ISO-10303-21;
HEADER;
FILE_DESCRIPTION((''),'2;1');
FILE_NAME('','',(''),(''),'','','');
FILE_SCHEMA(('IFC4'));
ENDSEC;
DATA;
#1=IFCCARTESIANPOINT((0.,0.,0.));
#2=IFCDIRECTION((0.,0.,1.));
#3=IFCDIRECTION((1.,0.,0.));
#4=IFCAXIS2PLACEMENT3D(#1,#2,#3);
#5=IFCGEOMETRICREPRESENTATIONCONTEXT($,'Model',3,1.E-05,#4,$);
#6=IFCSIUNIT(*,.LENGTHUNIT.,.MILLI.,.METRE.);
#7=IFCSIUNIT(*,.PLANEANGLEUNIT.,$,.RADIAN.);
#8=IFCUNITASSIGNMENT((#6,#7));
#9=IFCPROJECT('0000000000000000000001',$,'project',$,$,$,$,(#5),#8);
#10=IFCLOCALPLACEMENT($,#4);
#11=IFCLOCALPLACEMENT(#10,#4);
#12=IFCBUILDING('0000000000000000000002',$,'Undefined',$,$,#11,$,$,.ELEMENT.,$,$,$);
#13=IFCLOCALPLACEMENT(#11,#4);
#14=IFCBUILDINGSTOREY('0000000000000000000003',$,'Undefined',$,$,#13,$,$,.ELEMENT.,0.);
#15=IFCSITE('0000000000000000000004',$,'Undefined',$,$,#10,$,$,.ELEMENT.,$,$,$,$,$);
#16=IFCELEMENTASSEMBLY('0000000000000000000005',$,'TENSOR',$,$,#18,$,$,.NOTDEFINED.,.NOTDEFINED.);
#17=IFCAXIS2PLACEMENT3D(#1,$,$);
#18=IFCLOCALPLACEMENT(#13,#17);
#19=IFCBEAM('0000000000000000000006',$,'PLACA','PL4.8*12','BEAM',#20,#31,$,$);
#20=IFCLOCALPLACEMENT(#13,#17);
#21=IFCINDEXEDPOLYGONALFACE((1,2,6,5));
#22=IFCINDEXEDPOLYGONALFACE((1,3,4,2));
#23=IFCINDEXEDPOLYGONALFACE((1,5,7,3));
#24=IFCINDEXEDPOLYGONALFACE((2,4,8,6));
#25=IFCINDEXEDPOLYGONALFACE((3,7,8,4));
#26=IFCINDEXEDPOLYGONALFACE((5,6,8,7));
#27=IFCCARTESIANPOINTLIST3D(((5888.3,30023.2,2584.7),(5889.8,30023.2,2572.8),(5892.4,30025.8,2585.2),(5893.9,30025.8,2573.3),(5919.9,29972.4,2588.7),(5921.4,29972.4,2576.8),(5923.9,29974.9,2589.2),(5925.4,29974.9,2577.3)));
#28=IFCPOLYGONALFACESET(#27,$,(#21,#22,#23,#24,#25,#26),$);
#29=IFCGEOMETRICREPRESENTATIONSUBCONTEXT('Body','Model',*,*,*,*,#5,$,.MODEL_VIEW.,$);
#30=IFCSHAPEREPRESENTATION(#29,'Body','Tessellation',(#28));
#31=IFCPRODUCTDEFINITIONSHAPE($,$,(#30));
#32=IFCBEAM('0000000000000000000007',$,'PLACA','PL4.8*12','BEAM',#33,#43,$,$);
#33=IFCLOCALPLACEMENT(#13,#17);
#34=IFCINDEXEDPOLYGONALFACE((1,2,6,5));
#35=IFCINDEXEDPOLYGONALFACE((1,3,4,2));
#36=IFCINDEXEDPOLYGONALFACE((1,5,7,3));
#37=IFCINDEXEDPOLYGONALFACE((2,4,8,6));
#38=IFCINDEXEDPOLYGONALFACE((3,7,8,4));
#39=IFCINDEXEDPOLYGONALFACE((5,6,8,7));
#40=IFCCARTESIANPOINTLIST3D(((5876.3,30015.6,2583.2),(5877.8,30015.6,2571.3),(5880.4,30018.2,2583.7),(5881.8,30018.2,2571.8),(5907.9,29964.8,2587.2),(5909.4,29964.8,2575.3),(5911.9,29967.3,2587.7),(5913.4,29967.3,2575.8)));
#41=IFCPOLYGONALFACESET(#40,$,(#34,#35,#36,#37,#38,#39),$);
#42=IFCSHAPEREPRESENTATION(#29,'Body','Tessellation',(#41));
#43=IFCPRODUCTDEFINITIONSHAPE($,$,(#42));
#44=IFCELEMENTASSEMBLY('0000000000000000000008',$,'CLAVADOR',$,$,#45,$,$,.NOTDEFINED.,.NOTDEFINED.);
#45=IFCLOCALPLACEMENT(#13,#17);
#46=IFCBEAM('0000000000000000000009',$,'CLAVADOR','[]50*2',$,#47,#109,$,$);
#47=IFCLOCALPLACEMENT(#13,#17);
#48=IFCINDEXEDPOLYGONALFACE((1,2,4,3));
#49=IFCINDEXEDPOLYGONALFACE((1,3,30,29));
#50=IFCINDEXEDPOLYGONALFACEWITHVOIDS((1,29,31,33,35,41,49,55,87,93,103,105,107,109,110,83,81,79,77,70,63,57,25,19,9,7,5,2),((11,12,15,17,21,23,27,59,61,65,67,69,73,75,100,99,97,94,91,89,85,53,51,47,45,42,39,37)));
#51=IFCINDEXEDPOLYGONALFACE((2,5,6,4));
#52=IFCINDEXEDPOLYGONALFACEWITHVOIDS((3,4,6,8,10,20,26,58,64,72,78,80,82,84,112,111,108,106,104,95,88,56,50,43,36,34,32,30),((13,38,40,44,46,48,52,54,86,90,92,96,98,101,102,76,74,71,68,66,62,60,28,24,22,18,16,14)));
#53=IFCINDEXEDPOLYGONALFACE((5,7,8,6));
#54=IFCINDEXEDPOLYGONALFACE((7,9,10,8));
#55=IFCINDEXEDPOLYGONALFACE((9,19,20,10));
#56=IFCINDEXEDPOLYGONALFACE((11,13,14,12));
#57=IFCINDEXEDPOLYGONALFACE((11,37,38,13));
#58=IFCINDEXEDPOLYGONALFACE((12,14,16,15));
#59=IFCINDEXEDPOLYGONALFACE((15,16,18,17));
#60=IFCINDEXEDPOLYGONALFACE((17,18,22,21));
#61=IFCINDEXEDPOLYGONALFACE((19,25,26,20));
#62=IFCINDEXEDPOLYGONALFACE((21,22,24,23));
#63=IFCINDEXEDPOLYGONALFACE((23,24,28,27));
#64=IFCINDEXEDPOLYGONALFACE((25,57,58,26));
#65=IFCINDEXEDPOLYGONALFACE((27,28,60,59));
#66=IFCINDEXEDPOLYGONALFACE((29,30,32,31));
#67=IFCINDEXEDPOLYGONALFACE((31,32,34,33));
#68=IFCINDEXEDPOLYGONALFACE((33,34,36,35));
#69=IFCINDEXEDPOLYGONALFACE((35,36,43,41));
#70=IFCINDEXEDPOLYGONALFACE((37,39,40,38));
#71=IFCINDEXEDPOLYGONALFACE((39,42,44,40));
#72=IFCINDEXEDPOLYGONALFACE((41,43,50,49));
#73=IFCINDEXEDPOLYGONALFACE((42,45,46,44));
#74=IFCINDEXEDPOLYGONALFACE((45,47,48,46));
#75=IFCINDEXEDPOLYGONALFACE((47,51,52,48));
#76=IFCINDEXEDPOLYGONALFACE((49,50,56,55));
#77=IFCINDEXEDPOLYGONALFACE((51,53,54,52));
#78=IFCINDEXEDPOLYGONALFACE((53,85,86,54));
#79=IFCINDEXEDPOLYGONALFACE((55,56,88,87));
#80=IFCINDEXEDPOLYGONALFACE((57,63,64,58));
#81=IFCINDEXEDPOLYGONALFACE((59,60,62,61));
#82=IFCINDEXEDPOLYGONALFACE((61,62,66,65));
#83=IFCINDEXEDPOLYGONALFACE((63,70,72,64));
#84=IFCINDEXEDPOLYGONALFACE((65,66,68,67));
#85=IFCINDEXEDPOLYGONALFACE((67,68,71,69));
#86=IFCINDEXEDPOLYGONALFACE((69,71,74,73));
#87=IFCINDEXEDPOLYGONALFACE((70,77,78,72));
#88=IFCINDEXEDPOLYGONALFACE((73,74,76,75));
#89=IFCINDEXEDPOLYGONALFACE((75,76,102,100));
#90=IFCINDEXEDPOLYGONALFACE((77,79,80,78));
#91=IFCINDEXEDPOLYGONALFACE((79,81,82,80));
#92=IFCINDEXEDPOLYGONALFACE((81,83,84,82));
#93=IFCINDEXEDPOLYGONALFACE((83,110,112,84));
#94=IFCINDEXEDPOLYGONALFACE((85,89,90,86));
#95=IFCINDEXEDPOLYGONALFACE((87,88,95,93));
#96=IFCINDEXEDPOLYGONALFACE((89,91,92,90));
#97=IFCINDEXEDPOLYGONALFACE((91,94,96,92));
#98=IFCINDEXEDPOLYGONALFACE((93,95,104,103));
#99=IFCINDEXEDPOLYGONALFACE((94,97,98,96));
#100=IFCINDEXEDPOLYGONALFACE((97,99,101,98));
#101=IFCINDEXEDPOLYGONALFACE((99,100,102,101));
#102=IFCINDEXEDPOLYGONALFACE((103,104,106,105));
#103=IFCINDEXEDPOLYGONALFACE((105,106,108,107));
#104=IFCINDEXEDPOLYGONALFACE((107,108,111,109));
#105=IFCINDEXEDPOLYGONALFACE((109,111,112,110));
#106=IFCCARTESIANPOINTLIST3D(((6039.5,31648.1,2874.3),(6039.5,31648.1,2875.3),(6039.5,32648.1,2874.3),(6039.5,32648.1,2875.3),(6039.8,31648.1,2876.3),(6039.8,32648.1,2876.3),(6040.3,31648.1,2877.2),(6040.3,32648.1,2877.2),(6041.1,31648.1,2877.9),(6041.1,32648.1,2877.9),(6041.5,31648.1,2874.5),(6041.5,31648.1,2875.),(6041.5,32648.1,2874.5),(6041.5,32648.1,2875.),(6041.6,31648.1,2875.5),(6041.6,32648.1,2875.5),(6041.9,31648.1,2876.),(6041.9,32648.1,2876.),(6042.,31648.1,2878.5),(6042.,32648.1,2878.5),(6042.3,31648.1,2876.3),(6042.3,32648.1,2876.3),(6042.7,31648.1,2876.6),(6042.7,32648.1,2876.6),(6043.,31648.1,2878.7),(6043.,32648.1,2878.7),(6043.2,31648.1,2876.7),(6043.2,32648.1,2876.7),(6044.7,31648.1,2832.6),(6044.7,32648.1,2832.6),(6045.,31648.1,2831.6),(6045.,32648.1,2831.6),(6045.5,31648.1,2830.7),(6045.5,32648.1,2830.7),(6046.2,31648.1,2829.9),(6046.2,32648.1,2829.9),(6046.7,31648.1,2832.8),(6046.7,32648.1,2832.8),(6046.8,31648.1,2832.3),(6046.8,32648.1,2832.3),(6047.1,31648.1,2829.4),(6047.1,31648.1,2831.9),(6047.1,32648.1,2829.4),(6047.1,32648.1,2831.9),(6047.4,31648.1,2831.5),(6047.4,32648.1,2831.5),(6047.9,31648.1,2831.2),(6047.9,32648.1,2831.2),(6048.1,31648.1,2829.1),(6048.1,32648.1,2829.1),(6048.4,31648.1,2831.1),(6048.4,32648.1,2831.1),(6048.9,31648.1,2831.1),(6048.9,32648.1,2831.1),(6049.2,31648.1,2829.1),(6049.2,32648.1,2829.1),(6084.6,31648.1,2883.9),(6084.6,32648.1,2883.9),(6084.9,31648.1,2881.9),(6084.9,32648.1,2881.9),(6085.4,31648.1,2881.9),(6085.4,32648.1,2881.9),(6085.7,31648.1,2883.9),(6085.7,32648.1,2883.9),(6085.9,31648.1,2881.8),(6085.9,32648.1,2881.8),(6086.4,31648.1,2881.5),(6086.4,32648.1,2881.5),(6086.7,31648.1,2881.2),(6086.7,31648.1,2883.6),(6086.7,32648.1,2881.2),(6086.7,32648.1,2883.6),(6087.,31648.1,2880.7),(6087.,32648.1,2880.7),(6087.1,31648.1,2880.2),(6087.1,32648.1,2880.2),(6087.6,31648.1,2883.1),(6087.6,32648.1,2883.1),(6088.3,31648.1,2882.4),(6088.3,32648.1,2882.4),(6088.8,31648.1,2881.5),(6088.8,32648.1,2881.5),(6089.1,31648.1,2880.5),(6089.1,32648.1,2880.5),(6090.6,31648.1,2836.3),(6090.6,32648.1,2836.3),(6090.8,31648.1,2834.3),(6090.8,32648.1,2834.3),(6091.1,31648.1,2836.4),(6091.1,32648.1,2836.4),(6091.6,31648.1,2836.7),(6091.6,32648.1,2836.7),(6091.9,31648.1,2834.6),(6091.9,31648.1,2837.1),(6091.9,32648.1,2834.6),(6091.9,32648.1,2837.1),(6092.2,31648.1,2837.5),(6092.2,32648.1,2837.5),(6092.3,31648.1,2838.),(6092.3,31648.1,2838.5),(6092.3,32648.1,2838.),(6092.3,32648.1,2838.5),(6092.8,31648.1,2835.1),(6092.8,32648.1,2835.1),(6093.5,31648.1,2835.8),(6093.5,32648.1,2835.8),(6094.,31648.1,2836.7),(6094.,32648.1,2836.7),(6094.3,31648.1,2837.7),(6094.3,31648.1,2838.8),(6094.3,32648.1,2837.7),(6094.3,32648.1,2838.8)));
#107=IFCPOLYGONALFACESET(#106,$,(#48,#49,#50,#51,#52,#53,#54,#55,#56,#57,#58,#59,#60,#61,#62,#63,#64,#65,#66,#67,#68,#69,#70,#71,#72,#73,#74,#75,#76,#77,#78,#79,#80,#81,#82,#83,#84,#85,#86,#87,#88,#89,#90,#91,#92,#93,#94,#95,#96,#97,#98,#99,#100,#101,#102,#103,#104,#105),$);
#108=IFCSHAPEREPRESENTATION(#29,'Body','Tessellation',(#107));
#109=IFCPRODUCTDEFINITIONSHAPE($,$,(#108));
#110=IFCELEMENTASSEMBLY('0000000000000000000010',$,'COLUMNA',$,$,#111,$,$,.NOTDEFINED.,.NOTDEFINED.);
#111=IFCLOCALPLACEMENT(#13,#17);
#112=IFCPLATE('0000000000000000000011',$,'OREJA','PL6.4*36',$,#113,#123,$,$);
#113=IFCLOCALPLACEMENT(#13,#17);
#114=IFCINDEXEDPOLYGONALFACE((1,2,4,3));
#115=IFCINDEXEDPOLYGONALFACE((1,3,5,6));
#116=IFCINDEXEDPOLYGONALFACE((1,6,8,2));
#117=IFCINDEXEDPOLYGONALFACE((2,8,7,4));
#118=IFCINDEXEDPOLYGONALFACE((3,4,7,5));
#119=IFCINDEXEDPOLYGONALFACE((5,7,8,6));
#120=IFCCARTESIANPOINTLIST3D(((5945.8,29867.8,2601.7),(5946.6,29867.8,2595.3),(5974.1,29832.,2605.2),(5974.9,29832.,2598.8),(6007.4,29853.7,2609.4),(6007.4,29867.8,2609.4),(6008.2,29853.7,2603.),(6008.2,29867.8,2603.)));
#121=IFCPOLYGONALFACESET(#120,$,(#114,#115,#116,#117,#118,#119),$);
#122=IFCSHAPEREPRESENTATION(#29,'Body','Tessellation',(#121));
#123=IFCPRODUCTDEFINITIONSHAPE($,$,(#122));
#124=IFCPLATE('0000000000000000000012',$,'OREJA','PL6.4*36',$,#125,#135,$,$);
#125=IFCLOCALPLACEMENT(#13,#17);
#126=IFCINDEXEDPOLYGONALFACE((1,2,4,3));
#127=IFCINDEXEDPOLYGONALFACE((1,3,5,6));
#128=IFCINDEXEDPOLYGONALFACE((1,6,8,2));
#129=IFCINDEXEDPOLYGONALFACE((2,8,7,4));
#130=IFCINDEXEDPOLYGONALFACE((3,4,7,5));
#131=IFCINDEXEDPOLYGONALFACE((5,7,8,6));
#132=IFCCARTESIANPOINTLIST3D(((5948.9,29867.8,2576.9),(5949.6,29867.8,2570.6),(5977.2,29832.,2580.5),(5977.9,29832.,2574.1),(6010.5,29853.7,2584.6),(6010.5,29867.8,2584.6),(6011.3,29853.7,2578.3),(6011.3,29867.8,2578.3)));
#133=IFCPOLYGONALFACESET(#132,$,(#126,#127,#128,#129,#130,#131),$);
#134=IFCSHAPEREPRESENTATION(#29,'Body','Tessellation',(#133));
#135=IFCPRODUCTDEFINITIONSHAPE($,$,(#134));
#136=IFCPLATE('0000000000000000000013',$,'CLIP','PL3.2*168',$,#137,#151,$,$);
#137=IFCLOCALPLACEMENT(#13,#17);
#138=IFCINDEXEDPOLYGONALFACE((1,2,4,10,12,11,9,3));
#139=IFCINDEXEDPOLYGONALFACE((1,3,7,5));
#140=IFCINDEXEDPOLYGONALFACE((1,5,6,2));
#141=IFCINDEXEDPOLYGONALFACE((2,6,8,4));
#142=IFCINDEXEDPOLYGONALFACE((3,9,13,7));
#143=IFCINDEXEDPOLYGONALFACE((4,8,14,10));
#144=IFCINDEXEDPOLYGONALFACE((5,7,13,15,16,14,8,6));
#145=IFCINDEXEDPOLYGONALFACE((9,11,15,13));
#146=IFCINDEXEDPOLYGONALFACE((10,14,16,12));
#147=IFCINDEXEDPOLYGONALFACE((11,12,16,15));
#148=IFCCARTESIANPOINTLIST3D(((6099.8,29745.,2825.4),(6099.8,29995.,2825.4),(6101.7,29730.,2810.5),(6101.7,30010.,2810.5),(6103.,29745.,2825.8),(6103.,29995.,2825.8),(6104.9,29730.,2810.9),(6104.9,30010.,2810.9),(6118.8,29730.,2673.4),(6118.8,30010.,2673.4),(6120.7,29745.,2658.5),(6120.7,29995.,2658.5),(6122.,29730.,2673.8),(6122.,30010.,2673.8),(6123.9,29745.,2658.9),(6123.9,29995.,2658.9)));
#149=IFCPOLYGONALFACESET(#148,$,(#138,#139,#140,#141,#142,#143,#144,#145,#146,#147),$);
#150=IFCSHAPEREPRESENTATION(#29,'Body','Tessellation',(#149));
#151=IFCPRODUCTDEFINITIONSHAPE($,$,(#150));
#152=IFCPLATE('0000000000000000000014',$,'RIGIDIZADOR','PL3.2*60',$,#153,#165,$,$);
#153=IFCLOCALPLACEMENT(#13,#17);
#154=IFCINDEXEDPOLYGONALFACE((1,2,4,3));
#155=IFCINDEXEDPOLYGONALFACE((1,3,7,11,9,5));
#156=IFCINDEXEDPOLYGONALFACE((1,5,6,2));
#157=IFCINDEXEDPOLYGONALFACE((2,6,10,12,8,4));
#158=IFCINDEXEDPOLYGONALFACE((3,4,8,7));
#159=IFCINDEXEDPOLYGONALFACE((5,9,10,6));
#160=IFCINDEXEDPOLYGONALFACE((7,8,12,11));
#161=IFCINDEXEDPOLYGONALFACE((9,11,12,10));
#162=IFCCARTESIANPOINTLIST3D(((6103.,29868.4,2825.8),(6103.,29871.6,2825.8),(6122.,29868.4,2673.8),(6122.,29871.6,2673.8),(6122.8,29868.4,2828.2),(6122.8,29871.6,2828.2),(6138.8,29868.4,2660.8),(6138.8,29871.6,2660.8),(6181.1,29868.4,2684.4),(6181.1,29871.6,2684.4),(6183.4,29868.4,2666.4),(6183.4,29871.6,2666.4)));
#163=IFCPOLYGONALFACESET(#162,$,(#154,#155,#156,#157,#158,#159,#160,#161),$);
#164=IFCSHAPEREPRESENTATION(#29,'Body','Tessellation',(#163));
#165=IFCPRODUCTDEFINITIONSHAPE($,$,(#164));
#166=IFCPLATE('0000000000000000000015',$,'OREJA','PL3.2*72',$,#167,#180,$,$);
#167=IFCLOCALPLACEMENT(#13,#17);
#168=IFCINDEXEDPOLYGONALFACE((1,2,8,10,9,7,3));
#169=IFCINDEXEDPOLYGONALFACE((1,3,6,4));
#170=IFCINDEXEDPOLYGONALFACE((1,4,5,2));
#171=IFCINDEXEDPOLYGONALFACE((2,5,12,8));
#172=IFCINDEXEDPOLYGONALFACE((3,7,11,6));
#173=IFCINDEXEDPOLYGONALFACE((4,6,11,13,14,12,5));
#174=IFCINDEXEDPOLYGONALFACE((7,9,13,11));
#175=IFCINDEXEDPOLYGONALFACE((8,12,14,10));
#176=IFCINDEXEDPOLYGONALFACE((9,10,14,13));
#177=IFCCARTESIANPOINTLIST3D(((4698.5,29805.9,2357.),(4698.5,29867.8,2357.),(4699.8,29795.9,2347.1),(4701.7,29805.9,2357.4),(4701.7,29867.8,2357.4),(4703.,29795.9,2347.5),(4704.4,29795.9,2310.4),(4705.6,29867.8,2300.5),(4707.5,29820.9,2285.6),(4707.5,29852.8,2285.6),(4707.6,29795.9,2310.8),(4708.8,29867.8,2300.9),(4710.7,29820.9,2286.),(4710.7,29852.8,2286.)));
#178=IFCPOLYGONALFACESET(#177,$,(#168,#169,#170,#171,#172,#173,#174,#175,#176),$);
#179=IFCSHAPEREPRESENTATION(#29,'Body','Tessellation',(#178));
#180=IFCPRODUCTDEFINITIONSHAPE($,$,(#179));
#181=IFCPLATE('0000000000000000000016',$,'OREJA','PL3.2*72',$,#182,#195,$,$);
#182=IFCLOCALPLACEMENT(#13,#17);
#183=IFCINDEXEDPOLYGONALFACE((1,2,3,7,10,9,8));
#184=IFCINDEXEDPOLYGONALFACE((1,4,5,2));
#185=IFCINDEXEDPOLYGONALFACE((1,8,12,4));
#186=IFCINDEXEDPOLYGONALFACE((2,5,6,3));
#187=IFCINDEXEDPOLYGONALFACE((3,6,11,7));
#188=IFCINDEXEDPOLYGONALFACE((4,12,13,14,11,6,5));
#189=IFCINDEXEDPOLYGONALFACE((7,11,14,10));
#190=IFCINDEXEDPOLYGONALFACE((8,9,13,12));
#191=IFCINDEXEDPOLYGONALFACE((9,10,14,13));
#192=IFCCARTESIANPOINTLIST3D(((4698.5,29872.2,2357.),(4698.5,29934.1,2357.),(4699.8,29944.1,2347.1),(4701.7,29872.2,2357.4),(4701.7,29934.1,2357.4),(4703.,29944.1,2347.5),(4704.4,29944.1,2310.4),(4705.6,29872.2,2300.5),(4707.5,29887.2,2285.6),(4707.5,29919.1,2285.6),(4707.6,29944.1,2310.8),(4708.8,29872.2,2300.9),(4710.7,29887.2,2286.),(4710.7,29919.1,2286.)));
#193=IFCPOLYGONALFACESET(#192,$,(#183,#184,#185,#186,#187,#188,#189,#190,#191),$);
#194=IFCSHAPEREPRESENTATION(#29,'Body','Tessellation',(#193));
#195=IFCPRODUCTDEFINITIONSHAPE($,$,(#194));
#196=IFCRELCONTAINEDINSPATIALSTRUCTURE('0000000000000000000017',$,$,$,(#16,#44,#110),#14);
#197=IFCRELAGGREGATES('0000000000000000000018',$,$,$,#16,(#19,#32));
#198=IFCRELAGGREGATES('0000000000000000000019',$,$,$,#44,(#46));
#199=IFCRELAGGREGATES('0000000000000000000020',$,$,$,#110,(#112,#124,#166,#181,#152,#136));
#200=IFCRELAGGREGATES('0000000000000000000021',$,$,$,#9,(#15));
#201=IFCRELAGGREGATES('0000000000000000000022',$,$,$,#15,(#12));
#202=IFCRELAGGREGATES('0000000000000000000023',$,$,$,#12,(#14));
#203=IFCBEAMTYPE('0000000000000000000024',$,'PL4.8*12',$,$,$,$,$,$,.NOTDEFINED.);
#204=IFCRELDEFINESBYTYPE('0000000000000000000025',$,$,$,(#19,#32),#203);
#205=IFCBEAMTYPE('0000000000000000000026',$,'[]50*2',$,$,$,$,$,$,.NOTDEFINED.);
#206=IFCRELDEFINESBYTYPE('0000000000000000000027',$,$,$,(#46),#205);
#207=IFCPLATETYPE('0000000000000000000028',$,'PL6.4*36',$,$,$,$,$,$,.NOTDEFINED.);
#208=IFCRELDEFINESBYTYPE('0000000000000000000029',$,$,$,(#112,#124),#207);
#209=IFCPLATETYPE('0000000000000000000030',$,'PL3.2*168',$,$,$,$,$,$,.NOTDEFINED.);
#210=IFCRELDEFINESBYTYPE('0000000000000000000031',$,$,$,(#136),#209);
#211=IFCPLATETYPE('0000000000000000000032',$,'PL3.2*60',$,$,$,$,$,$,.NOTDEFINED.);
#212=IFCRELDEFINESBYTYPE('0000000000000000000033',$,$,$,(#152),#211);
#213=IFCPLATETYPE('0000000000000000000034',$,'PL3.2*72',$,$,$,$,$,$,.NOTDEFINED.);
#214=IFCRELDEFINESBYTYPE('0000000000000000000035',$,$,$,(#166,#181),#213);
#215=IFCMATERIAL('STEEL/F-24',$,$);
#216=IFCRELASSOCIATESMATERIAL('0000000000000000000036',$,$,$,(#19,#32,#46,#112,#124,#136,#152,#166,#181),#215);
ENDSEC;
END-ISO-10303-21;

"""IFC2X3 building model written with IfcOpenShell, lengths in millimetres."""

from ifc_helpers import new_model, si_unit, frame, origin_with_axes, origin_2d_with_axis, place, context, subcontext, project, spatial, polyline, rectangle, hollow_rectangle, outline, extrude, material, type_object, element, aggregate, save


model = new_model("IFC2X3")

# Units and contexts
model_context = context("Model", 3, precision=1e-05, world=origin_with_axes())
body_context = subcontext(model_context, "Body", "Model", "MODEL_VIEW")
ifc_project = project(units=[si_unit("LENGTHUNIT", "METRE", prefix="MILLI"), si_unit("PLANEANGLEUNIT", "RADIAN")], contexts=[model_context])

# Site, building, storey
site_placement = place(None, origin_with_axes())
site = spatial("IfcSite", under=ifc_project, at=site_placement, Name="Undefined", CompositionType="ELEMENT")
building_placement = place(site_placement, origin_with_axes())
building = spatial("IfcBuilding", under=site, at=building_placement, Name="Undefined", CompositionType="ELEMENT")
storey_placement = place(building_placement, origin_with_axes())
storey = spatial("IfcBuildingStorey", under=building, at=storey_placement, Name="Undefined", CompositionType="ELEMENT", Elevation=0.0)

# Element assembly, beams
assembly_1_placement = place(storey_placement, origin_with_axes())
assembly_1 = element("IfcElementAssembly", 1, at=assembly_1_placement, inside=storey, Name="TENSOR", AssemblyPlace="NOTDEFINED", PredefinedType="NOTDEFINED")
ifc_material_1 = material(Name="STEEL/F-24")
beam_type_1 = type_object("IfcBeamType", Name="PL4.8*12", PredefinedType="NOTDEFINED")
beam_1_placement = place(assembly_1_placement, frame((5891.1, 30024.5, 2579.0), z_axis=(0.124075, 0.0, -0.992273), x_axis=(0.526076, -0.84789, 0.065781)))
beam_1 = element("IfcBeam", 2, at=beam_1_placement, type_object=beam_type_1, material=ifc_material_1, Name="PLACA", Description="PL4.8*12", ObjectType="BEAM", context=body_context, shape_type="SweptSolid", body=[
    extrude(rectangle(XDim=4.8, YDim=12.0, at=origin_2d_with_axis()), frame((60.0, 0.0, 0.0), z_axis=(-1.0, 0.0, 0.0), x_axis=(0.0, -1.0, 0.0)), (0.0, 0.0, 1.0), 60.0),
])
beam_2_placement = place(assembly_1_placement, frame((5879.1, 30016.9, 2577.5), z_axis=(0.124075, 0.0, -0.992273), x_axis=(0.526076, -0.84789, 0.065781)))
beam_2 = element("IfcBeam", 3, at=beam_2_placement, type_object=beam_type_1, material=ifc_material_1, Name="PLACA", Description="PL4.8*12", ObjectType="BEAM", context=body_context, shape_type="SweptSolid", body=[
    extrude(rectangle(XDim=4.8, YDim=12.0, at=origin_2d_with_axis()), frame((60.0, 0.0, 0.0), z_axis=(-1.0, 0.0, 0.0), x_axis=(0.0, -1.0, 0.0)), (0.0, 0.0, 1.0), 60.0),
])
aggregate(assembly_1, [beam_1, beam_2])

# Element assembly, beam
assembly_2_placement = place(storey_placement, origin_with_axes())
assembly_2 = element("IfcElementAssembly", 4, at=assembly_2_placement, inside=storey, Name="CLAVADOR", AssemblyPlace="NOTDEFINED", PredefinedType="NOTDEFINED")
beam_type_2 = type_object("IfcBeamType", Name="[]50*2", PredefinedType="NOTDEFINED")
beam_3_placement = place(assembly_2_placement, frame((6066.9, 31648.1, 2856.5), z_axis=(-0.992273, 0.0, -0.124075), x_axis=(0.0, 1.0, 0.000001)))
beam_3 = element("IfcBeam", 5, at=beam_3_placement, type_object=beam_type_2, material=ifc_material_1, Name="CLAVADOR", Description="[]50*2", context=body_context, shape_type="SweptSolid", body=[
    extrude(hollow_rectangle(XDim=50.0, YDim=50.0, WallThickness=2.0, InnerFilletRadius=2.0, OuterFilletRadius=4.0, at=origin_2d_with_axis()), frame((1000.0, 0.0, 0.0), z_axis=(-1.0, 0.0, 0.0), x_axis=(0.0, -1.0, 0.0)), (0.0, 0.0, 1.0), 1000.0),
])
aggregate(assembly_2, [beam_3])

# Element assembly, plates
assembly_3_placement = place(storey_placement, origin_with_axes())
assembly_3 = element("IfcElementAssembly", 6, at=assembly_3_placement, inside=storey, Name="COLUMNA", AssemblyPlace="NOTDEFINED", PredefinedType="NOTDEFINED")
plate_type_1 = type_object("IfcPlateType", Name="PL6.4*36", PredefinedType="NOTDEFINED")
plate_1_placement = place(assembly_3_placement, frame((6007.8, 29867.8, 2606.2), z_axis=(-0.124075, 0.0, 0.992273), x_axis=(-0.992273, 0.0, -0.124075)))
plate_1 = element("IfcPlate", 7, at=plate_1_placement, type_object=plate_type_1, material=ifc_material_1, Name="OREJA", Description="PL6.4*36", context=body_context, shape_type="SweptSolid", body=[
    extrude(outline(polyline([(0.0, 0.0), (62.1, 0.0), (33.6, 35.8), (0.0, 14.0), (0.0, 0.0)])), frame((0.0, 0.0, -3.2), z_axis=(0.0, 0.0, 1.0), x_axis=(1.0, 0.0, 0.0)), (0.0, 0.0, 1.0), 6.4),
])
plate_2_placement = place(assembly_3_placement, frame((6010.9, 29867.8, 2581.5), z_axis=(-0.124075, 0.0, 0.992273), x_axis=(-0.992273, 0.0, -0.124075)))
plate_2 = element("IfcPlate", 8, at=plate_2_placement, type_object=plate_type_1, material=ifc_material_1, Name="OREJA", Description="PL6.4*36", context=body_context, shape_type="SweptSolid", body=[
    extrude(outline(polyline([(0.0, 0.0), (62.1, 0.0), (33.6, 35.8), (0.0, 14.0), (0.0, 0.0)])), frame((0.0, 0.0, -3.2), z_axis=(0.0, 0.0, 1.0), x_axis=(1.0, 0.0, 0.0)), (0.0, 0.0, 1.0), 6.4),
])
plate_type_2 = type_object("IfcPlateType", Name="PL3.2*168", PredefinedType="NOTDEFINED")
plate_3_placement = place(assembly_3_placement, frame((6101.4, 29730.0, 2825.6), z_axis=(-0.992271, 0.0, -0.124089), x_axis=(0.0, 1.0, 0.0)))
plate_3 = element("IfcPlate", 9, at=plate_3_placement, type_object=plate_type_2, material=ifc_material_1, Name="CLIP", Description="PL3.2*168", context=body_context, shape_type="SweptSolid", body=[
    extrude(outline(polyline([(0.0, 15.0), (15.0, 0.0), (265.0, 0.0), (280.0, 15.0), (280.0, 153.1), (265.0, 168.1), (15.0, 168.1), (0.0, 153.1), (0.0, 15.0)])), frame((0.0, 0.0, -1.6), z_axis=(0.0, 0.0, 1.0), x_axis=(1.0, 0.0, 0.0)), (0.0, 0.0, 1.0), 3.2),
])
plate_type_3 = type_object("IfcPlateType", Name="PL3.2*60", PredefinedType="NOTDEFINED")
plate_4_placement = place(assembly_3_placement, frame((6103.0, 29870.0, 2825.8), z_axis=(0.0, 1.0, 0.0), x_axis=(0.992245, 0.0, 0.124299)))
plate_4 = element("IfcPlate", 10, at=plate_4_placement, type_object=plate_type_3, material=ifc_material_1, Name="RIGIDIZADOR", Description="PL3.2*60", context=body_context, shape_type="SweptSolid", body=[
    extrude(outline(polyline([(0.0, 0.0), (20.0, 0.0), (60.0, 150.0), (60.0, 168.1), (15.0, 168.1), (0.0, 153.1), (0.0, 0.0)])), frame((0.0, 0.0, -1.6), z_axis=(0.0, 0.0, 1.0), x_axis=(1.0, 0.0, 0.0)), (0.0, 0.0, 1.0), 3.2),
])
plate_type_4 = type_object("IfcPlateType", Name="PL3.2*72", PredefinedType="NOTDEFINED")
plate_5_placement = place(assembly_3_placement, frame((4709.1, 29867.8, 2285.8), z_axis=(-0.992251, 0.0, -0.124252), x_axis=(0.0, -1.0, 0.0)))
plate_5 = element("IfcPlate", 11, at=plate_5_placement, type_object=plate_type_4, material=ifc_material_1, Name="OREJA", Description="PL3.2*72", context=body_context, shape_type="SweptSolid", body=[
    extrude(outline(polyline([(0.0, 15.0), (15.0, 0.0), (47.0, 0.0), (72.0, 25.0), (72.0, 62.0), (62.0, 72.0), (0.0, 72.0), (0.0, 15.0)])), frame((0.0, 0.0, -1.6), z_axis=(0.0, 0.0, 1.0), x_axis=(1.0, 0.0, 0.0)), (0.0, 0.0, 1.0), 3.2),
])
plate_6_placement = place(assembly_3_placement, frame((4709.1, 29872.2, 2285.8), z_axis=(0.992251, 0.0, 0.124252), x_axis=(0.0, 1.0, 0.0)))
plate_6 = element("IfcPlate", 12, at=plate_6_placement, type_object=plate_type_4, material=ifc_material_1, Name="OREJA", Description="PL3.2*72", context=body_context, shape_type="SweptSolid", body=[
    extrude(outline(polyline([(0.0, 15.0), (15.0, 0.0), (47.0, 0.0), (72.0, 25.0), (72.0, 62.0), (62.0, 72.0), (0.0, 72.0), (0.0, 15.0)])), frame((0.0, 0.0, -1.6), z_axis=(0.0, 0.0, 1.0), x_axis=(1.0, 0.0, 0.0)), (0.0, 0.0, 1.0), 3.2),
])

aggregate(assembly_3, [plate_1, plate_2, plate_5, plate_6, plate_4, plate_3])

save(model, "model.ifc")
